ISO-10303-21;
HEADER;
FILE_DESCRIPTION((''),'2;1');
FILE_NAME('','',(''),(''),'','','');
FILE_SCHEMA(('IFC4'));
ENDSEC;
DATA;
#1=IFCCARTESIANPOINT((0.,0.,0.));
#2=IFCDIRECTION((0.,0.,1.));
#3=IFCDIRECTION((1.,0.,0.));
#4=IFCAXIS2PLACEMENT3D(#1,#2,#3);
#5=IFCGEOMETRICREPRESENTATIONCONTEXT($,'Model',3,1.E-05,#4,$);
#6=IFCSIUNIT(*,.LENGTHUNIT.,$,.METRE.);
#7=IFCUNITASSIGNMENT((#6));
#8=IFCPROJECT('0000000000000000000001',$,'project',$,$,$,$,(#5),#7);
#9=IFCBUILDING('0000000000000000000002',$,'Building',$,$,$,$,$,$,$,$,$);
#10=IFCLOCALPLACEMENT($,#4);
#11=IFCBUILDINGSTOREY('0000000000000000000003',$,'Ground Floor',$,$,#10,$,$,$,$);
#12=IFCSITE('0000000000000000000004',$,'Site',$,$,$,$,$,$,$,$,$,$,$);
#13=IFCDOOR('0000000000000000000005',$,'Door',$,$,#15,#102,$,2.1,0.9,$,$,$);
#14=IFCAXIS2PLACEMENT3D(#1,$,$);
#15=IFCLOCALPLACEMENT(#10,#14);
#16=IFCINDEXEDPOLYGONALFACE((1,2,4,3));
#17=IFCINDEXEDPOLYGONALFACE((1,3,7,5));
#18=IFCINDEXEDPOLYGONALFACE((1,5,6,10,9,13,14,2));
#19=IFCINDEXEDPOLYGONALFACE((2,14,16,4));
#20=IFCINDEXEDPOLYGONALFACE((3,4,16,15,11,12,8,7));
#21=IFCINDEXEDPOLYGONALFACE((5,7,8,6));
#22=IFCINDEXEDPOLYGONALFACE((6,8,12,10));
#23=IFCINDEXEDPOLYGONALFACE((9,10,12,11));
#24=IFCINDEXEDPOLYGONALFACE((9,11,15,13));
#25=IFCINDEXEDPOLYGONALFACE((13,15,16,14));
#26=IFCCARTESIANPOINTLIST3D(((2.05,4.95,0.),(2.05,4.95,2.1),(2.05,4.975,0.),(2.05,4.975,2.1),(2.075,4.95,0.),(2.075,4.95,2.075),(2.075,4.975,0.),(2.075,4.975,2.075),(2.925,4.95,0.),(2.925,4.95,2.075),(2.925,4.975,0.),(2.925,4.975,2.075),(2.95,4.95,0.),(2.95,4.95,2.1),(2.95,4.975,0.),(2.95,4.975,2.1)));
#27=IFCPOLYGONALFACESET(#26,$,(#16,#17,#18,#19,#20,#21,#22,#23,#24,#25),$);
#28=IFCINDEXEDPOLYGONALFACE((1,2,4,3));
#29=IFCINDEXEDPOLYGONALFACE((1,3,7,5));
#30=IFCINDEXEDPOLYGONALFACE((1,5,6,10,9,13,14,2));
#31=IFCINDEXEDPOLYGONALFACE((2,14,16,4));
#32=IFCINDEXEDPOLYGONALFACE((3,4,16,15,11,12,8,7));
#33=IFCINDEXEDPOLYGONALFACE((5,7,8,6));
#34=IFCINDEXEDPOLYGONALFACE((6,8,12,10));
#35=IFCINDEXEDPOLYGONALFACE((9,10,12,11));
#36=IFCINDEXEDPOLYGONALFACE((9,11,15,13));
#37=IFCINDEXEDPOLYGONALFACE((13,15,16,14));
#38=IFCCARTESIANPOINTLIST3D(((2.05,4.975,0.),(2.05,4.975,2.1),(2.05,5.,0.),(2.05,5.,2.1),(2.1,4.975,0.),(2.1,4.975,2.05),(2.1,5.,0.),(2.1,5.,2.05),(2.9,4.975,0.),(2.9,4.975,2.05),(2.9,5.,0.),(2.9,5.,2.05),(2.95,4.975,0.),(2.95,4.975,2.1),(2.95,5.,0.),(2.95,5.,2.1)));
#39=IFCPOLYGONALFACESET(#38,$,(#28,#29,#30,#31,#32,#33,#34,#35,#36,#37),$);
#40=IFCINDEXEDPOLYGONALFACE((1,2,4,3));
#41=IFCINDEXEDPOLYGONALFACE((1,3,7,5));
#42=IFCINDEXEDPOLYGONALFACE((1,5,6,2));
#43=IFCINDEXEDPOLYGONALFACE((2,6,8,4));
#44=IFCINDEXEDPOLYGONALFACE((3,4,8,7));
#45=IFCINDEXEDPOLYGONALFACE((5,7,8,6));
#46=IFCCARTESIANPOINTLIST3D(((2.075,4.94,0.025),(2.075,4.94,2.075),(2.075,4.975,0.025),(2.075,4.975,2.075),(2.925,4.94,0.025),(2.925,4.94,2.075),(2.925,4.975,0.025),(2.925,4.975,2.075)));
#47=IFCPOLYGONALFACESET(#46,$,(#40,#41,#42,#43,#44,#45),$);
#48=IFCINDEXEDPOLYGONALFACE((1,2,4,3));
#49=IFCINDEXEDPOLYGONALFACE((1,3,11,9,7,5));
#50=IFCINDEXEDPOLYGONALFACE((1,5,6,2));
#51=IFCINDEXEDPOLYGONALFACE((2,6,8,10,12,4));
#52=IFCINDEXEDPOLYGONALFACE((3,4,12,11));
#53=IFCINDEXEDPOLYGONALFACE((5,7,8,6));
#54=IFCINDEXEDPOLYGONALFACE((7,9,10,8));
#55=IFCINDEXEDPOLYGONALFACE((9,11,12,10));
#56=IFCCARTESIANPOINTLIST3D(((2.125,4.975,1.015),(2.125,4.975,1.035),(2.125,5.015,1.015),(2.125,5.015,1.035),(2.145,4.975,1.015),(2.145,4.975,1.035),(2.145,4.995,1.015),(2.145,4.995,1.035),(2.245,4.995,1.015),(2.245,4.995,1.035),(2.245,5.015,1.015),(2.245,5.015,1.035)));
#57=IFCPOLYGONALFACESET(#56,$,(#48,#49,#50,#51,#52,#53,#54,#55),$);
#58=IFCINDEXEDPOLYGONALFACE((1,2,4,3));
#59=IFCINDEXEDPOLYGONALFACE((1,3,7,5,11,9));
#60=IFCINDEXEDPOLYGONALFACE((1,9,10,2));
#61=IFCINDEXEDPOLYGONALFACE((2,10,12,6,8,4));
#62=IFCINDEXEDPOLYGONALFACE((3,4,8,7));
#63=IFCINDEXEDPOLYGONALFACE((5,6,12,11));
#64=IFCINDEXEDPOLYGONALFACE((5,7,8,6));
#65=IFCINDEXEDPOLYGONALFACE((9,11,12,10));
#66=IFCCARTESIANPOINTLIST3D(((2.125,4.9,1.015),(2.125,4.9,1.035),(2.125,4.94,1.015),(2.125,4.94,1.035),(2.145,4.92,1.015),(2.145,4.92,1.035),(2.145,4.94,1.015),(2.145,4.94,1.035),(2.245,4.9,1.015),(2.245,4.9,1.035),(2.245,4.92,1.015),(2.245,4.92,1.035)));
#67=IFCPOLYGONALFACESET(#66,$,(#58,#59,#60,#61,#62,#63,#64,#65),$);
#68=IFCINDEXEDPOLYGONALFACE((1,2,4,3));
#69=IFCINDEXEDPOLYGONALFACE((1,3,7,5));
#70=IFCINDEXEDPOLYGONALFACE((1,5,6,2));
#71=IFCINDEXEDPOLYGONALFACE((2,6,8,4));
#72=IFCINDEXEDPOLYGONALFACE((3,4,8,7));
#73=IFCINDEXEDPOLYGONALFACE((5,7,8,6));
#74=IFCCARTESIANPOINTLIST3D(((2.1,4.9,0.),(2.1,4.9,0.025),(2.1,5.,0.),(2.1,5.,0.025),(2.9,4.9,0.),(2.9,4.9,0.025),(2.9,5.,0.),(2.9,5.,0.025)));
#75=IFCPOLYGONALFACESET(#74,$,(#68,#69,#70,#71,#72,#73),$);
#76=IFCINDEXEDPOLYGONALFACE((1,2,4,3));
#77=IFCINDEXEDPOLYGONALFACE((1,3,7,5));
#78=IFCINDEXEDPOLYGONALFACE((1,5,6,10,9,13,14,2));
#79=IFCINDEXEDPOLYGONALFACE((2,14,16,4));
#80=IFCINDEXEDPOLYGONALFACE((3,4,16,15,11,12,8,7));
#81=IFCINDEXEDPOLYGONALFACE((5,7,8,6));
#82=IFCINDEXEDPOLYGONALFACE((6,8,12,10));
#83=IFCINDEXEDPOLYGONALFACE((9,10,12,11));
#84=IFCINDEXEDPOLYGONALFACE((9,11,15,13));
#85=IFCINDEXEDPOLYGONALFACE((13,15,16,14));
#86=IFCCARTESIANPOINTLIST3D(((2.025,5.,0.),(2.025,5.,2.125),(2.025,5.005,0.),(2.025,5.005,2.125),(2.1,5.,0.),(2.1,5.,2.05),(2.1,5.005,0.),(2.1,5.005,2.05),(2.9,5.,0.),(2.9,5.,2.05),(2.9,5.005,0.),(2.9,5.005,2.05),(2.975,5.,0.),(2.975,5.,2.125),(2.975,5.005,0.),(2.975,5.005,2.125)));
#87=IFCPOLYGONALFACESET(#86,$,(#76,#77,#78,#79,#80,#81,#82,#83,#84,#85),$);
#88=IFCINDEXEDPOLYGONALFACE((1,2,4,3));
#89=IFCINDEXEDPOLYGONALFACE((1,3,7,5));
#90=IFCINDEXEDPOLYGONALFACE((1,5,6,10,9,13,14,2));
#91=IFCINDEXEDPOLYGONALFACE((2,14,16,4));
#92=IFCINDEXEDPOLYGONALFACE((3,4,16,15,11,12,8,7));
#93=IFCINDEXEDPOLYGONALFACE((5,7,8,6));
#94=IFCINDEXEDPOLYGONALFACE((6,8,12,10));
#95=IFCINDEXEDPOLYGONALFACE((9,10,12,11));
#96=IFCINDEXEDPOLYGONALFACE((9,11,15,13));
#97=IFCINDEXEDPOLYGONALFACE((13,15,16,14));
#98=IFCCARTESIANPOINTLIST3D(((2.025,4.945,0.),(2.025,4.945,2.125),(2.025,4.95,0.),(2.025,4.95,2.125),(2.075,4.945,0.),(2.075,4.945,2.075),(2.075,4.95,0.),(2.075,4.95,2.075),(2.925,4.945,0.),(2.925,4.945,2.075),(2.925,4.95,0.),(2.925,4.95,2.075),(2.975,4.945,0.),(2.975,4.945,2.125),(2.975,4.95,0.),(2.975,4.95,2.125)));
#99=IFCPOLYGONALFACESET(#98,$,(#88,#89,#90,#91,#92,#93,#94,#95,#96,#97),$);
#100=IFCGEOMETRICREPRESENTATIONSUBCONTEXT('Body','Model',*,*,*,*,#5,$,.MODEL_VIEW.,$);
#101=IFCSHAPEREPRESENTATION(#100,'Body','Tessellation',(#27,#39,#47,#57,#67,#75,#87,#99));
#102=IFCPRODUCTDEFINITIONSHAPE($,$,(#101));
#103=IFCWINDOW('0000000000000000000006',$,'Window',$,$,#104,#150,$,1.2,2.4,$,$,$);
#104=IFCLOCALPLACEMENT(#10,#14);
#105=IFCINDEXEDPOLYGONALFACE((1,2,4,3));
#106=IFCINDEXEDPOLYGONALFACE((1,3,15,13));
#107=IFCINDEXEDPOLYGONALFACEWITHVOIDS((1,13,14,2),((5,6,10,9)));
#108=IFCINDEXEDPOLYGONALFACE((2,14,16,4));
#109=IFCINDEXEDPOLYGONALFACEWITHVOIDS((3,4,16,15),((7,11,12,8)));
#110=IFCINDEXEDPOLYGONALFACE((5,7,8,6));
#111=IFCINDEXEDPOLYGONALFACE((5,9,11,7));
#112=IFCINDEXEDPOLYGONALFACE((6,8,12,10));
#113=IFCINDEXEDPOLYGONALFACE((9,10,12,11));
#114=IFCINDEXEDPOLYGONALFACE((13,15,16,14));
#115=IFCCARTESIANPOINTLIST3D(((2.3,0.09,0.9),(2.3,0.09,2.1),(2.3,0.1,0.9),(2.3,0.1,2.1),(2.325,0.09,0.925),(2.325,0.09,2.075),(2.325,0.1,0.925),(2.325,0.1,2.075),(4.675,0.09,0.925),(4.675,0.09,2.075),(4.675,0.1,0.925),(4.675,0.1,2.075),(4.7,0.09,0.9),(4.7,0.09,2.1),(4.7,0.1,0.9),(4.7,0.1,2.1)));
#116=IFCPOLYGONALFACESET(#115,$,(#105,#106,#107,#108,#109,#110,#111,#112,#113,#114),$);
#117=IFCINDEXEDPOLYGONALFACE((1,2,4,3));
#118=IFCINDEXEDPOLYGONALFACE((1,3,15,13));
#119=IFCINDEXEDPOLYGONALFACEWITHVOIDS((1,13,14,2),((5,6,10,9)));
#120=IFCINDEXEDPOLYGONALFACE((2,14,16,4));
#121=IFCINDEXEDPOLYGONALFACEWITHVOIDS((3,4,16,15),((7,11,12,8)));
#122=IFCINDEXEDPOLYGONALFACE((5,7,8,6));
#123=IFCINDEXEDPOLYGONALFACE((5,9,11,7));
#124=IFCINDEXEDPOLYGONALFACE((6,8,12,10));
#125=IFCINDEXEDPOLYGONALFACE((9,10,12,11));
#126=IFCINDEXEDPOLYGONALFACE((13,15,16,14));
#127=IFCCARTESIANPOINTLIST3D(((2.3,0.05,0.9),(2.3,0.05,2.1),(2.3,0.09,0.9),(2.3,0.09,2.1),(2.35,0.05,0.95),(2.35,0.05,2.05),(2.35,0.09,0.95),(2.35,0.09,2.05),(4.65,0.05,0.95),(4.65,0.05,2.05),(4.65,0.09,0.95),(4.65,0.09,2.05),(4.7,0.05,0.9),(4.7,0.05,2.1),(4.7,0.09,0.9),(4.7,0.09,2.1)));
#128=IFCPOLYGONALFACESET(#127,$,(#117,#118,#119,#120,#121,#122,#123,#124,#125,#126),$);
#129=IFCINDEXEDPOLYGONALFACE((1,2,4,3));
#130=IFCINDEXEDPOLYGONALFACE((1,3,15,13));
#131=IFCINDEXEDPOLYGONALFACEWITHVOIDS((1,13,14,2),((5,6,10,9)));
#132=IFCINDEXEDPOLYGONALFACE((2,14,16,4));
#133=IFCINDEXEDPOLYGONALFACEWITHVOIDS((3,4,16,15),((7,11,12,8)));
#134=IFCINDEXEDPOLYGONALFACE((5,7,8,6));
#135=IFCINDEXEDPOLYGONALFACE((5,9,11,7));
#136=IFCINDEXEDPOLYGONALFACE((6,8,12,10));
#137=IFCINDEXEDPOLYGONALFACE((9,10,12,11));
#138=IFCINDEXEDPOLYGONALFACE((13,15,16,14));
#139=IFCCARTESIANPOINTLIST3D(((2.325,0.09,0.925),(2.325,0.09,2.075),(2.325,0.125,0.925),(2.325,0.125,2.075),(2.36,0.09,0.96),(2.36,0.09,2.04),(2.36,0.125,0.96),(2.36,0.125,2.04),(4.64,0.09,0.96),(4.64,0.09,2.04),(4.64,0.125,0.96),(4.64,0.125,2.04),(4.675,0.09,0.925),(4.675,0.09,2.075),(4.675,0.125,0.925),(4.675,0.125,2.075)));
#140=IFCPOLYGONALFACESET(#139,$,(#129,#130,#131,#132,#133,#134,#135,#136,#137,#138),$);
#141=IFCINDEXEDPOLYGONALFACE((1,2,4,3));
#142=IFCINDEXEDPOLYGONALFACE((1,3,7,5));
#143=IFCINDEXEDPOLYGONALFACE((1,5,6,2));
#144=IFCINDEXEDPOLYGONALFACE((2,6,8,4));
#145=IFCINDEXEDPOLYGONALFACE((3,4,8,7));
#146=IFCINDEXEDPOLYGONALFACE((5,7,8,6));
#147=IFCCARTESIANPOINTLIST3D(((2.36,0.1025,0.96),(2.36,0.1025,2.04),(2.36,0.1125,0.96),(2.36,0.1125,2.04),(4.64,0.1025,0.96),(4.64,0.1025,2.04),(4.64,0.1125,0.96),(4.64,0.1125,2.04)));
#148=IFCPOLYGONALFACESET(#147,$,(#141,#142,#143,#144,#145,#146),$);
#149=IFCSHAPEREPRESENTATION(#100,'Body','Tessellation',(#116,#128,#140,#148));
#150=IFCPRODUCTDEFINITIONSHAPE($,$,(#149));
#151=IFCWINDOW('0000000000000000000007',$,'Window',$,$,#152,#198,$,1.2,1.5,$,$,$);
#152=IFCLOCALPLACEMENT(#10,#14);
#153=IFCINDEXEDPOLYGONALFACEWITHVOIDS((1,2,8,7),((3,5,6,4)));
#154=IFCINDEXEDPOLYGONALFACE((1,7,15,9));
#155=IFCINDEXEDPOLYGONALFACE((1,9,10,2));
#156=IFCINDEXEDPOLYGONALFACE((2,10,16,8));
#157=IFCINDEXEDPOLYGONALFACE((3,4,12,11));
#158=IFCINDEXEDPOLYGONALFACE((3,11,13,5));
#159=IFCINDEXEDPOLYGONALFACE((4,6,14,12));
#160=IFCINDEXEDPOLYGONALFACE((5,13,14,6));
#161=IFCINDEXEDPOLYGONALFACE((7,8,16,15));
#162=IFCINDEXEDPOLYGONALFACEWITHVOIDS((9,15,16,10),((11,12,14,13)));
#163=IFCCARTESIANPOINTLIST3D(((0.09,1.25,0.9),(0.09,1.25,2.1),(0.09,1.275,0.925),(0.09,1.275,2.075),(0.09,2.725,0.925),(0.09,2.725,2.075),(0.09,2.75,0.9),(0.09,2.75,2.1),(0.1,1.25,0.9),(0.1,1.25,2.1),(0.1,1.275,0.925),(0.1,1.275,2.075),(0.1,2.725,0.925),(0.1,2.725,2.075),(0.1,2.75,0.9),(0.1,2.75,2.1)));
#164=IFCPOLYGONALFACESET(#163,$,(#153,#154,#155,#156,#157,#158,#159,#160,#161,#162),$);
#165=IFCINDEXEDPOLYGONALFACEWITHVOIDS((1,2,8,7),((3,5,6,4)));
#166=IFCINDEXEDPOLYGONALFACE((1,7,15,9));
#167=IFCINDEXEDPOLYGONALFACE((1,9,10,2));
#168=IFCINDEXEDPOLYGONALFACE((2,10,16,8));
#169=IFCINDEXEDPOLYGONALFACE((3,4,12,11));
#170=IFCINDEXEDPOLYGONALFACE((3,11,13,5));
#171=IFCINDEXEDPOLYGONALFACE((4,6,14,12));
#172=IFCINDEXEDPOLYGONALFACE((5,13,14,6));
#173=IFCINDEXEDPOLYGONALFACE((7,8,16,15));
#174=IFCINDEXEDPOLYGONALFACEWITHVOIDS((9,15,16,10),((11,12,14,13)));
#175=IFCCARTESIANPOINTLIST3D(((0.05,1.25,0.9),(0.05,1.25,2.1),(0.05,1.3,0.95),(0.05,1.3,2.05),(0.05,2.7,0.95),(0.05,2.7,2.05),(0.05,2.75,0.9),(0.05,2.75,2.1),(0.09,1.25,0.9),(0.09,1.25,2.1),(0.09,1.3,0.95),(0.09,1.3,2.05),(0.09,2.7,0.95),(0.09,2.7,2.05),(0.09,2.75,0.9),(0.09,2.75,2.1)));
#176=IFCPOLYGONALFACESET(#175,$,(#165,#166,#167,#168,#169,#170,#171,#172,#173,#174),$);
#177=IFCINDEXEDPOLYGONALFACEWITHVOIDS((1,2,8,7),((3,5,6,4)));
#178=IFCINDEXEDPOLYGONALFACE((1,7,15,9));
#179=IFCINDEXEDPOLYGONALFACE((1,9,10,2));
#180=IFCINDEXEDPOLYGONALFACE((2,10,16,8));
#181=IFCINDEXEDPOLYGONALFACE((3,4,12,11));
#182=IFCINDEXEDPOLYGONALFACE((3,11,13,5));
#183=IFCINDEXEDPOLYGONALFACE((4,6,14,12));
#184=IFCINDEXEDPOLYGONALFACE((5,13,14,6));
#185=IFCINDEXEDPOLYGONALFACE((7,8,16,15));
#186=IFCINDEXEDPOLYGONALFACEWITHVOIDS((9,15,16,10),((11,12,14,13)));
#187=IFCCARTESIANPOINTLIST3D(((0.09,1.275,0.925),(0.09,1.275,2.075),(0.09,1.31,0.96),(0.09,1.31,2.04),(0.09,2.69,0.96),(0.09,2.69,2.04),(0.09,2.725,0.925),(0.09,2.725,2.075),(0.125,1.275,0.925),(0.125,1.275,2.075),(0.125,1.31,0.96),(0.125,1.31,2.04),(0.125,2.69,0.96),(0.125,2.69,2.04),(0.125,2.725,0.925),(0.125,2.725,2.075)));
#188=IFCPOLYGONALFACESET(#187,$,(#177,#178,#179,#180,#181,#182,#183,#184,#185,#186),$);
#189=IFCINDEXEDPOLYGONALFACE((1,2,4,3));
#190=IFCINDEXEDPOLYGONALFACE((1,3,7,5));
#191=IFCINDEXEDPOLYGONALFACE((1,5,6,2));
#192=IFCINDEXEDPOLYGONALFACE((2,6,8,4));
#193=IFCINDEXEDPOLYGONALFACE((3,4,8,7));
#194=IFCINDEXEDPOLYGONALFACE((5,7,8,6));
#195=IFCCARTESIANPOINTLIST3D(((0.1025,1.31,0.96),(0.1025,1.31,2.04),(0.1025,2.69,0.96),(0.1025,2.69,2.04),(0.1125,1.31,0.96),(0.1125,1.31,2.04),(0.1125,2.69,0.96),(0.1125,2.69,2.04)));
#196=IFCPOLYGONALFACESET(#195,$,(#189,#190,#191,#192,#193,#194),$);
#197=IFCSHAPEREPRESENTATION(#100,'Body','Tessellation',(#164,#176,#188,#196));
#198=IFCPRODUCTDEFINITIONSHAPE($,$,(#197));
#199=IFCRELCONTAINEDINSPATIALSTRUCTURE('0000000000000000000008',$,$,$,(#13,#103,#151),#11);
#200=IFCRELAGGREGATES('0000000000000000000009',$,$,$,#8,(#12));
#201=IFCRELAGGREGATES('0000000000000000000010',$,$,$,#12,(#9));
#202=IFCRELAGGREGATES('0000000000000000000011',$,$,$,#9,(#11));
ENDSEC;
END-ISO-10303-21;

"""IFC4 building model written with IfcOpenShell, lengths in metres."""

from ifc_helpers import new_model, si_unit, frame, origin_with_axes, place, context, subcontext, project, spatial, line, indexed_curve, outline, extrude, element, save


model = new_model("IFC4")

# Units and contexts
model_context = context("Model", 3, precision=1e-05, world=origin_with_axes())
body_context = subcontext(model_context, "Body", "Model", "MODEL_VIEW")
ifc_project = project(units=[si_unit("LENGTHUNIT", "METRE")], contexts=[model_context])

# Site, building, storey
site = spatial("IfcSite", under=ifc_project, Name="Site")
building = spatial("IfcBuilding", under=site, Name="Building")
storey_placement = place(None, origin_with_axes())
storey = spatial("IfcBuildingStorey", under=building, at=storey_placement, Name="Ground Floor")

# Door
door_1_placement = place(storey_placement, frame((2.95, 5.0, 0.0), z_axis=(0.0, 0.0, 1.0), x_axis=(-1.0, 0.0, 0.0)))
element("IfcDoor", 1, at=door_1_placement, inside=storey, Name="Door", OverallHeight=2.1, OverallWidth=0.9, context=body_context, shape_type="SweptSolid", body=[
    extrude(outline(indexed_curve([(0.0, 0.0), (0.0, 2.1), (0.9, 2.1), (0.9, 0.0), (0.875, 0.0), (0.875, 2.075), (0.025, 2.075), (0.025, 0.0)], segments=[line(1, 2, 3, 4, 5, 6, 7, 8, 1)])), frame((0.0, 0.025, 0.0), z_axis=(0.0, -1.0, 0.0), x_axis=(1.0, 0.0, 0.0)), (0.0, 0.0, -1.0), 0.025),
    extrude(outline(indexed_curve([(0.0, 0.0), (0.0, 2.1), (0.9, 2.1), (0.9, 0.0), (0.85, 0.0), (0.85, 2.05), (0.05, 2.05), (0.05, 0.0)], segments=[line(1, 2, 3, 4, 5, 6, 7, 8, 1)])), frame((0.0, 0.0, 0.0), z_axis=(0.0, -1.0, 0.0), x_axis=(1.0, 0.0, 0.0)), (0.0, 0.0, -1.0), 0.025),
    extrude(outline(indexed_curve([(0.0, 0.0), (0.85, 0.0), (0.85, 0.035), (0.0, 0.035)], segments=[line(1, 2, 3, 4, 1)])), frame((0.025, 0.025, 0.025), z_axis=(0.0, 0.0, 1.0), x_axis=(1.0, 0.0, 0.0)), (0.0, 0.0, 1.0), 2.05),
    extrude(outline(indexed_curve([(0.0, 0.0), (0.0, -0.04), (-0.12, -0.04), (-0.12, -0.02), (-0.02, -0.02), (-0.02, 0.0)], segments=[line(1, 2, 3, 4, 5, 6, 1)])), frame((0.825, 0.025, 1.015), z_axis=(0.0, 0.0, 1.0), x_axis=(1.0, 0.0, 0.0)), (0.0, 0.0, 1.0), 0.02),
    extrude(outline(indexed_curve([(0.0, 0.0), (0.0, 0.04), (-0.12, 0.04), (-0.12, 0.02), (-0.02, 0.02), (-0.02, 0.0)], segments=[line(1, 2, 3, 4, 5, 6, 1)])), frame((0.825, 0.06, 1.015), z_axis=(0.0, 0.0, 1.0), x_axis=(1.0, 0.0, 0.0)), (0.0, 0.0, 1.0), 0.02),
    extrude(outline(indexed_curve([(0.0, 0.0), (0.8, 0.0), (0.8, 0.1), (0.0, 0.1)], segments=[line(1, 2, 3, 4, 1)])), frame((0.05, 0.0, 0.0), z_axis=(0.0, 0.0, 1.0), x_axis=(1.0, 0.0, 0.0)), (0.0, 0.0, 1.0), 0.025),
    extrude(outline(indexed_curve([(0.0, 0.0), (0.0, 2.125), (0.95, 2.125), (0.95, 0.0), (0.875, 0.0), (0.875, 2.05), (0.075, 2.05), (0.075, 0.0)], segments=[line(1, 2, 3, 4, 5, 6, 7, 8, 1)])), frame((-0.025, -0.005, 0.0), z_axis=(0.0, -1.0, 0.0), x_axis=(1.0, 0.0, 0.0)), (0.0, 0.0, -1.0), 0.005),
    extrude(outline(indexed_curve([(0.0, 0.0), (0.0, 2.125), (0.95, 2.125), (0.95, 0.0), (0.9, 0.0), (0.9, 2.075), (0.05, 2.075), (0.05, 0.0)], segments=[line(1, 2, 3, 4, 5, 6, 7, 8, 1)])), frame((-0.025, 0.05, 0.0), z_axis=(0.0, -1.0, 0.0), x_axis=(1.0, 0.0, 0.0)), (0.0, 0.0, -1.0), 0.005),
])

# Windows
window_placement = place(storey_placement, frame((2.3, 0.0, 0.9), z_axis=(0.0, 0.0, 1.0), x_axis=(1.0, 0.0, 0.0)))
element("IfcWindow", 2, at=window_placement, inside=storey, Name="Window", OverallHeight=1.2, OverallWidth=2.4, context=body_context, shape_type="SweptSolid", body=[
    extrude(outline(indexed_curve([(0.0, 0.0), (2.4, 0.0), (2.4, 1.2), (0.0, 1.2)], segments=[line(1, 2, 3, 4, 1)]), holes=[indexed_curve([(0.025, 0.025), (2.375, 0.025), (2.375, 1.175), (0.025, 1.175)], segments=[line(1, 2, 3, 4, 1)])]), frame((0.0, 0.09, 0.0), z_axis=(0.0, -1.0, 0.0), x_axis=(1.0, 0.0, 0.0)), (0.0, 0.0, -1.0), 0.01),
    extrude(outline(indexed_curve([(0.0, 0.0), (2.4, 0.0), (2.4, 1.2), (0.0, 1.2)], segments=[line(1, 2, 3, 4, 1)]), holes=[indexed_curve([(0.05, 0.05), (2.35, 0.05), (2.35, 1.15), (0.05, 1.15)], segments=[line(1, 2, 3, 4, 1)])]), frame((0.0, 0.05, 0.0), z_axis=(0.0, -1.0, 0.0), x_axis=(1.0, 0.0, 0.0)), (0.0, 0.0, -1.0), 0.04),
    extrude(outline(indexed_curve([(0.0, 0.0), (2.35, 0.0), (2.35, 1.15), (0.0, 1.15)], segments=[line(1, 2, 3, 4, 1)]), holes=[indexed_curve([(0.035, 0.035), (2.315, 0.035), (2.315, 1.115), (0.035, 1.115)], segments=[line(1, 2, 3, 4, 1)])]), frame((0.025, 0.09, 0.025), z_axis=(0.0, -1.0, 0.0), x_axis=(1.0, 0.0, 0.0)), (0.0, 0.0, -1.0), 0.035),
    extrude(outline(indexed_curve([(0.035, 0.035), (2.315, 0.035), (2.315, 1.115), (0.035, 1.115)], segments=[line(1, 2, 3, 4, 1)])), frame((0.025, 0.1025, 0.025), z_axis=(0.0, -1.0, 0.0), x_axis=(1.0, 0.0, 0.0)), (0.0, 0.0, -1.0), 0.01),
])
for number, where, z_axis, x_axis, name in (
    (3, (0.0, 2.75, 0.9), (0.0, 0.0, 1.0), (0.0, -1.0, 0.0), "Window"),
):
    element("IfcWindow", number, at=place(storey_placement, frame(where, z_axis=z_axis, x_axis=x_axis)), inside=storey, Name=name, OverallHeight=1.2, OverallWidth=1.5, context=body_context, shape_type="SweptSolid", body=[
        extrude(outline(indexed_curve([(0.0, 0.0), (1.5, 0.0), (1.5, 1.2), (0.0, 1.2)], segments=[line(1, 2, 3, 4, 1)]), holes=[indexed_curve([(0.025, 0.025), (1.475, 0.025), (1.475, 1.175), (0.025, 1.175)], segments=[line(1, 2, 3, 4, 1)])]), frame((0.0, 0.09, 0.0), z_axis=(0.0, -1.0, 0.0), x_axis=(1.0, 0.0, 0.0)), (0.0, 0.0, -1.0), 0.01),
        extrude(outline(indexed_curve([(0.0, 0.0), (1.5, 0.0), (1.5, 1.2), (0.0, 1.2)], segments=[line(1, 2, 3, 4, 1)]), holes=[indexed_curve([(0.05, 0.05), (1.45, 0.05), (1.45, 1.15), (0.05, 1.15)], segments=[line(1, 2, 3, 4, 1)])]), frame((0.0, 0.05, 0.0), z_axis=(0.0, -1.0, 0.0), x_axis=(1.0, 0.0, 0.0)), (0.0, 0.0, -1.0), 0.04),
        extrude(outline(indexed_curve([(0.0, 0.0), (1.45, 0.0), (1.45, 1.15), (0.0, 1.15)], segments=[line(1, 2, 3, 4, 1)]), holes=[indexed_curve([(0.035, 0.035), (1.415, 0.035), (1.415, 1.115), (0.035, 1.115)], segments=[line(1, 2, 3, 4, 1)])]), frame((0.025, 0.09, 0.025), z_axis=(0.0, -1.0, 0.0), x_axis=(1.0, 0.0, 0.0)), (0.0, 0.0, -1.0), 0.035),
        extrude(outline(indexed_curve([(0.035, 0.035), (1.415, 0.035), (1.415, 1.115), (0.035, 1.115)], segments=[line(1, 2, 3, 4, 1)])), frame((0.025, 0.1025, 0.025), z_axis=(0.0, -1.0, 0.0), x_axis=(1.0, 0.0, 0.0)), (0.0, 0.0, -1.0), 0.01),
    ])

save(model, "model.ifc")
